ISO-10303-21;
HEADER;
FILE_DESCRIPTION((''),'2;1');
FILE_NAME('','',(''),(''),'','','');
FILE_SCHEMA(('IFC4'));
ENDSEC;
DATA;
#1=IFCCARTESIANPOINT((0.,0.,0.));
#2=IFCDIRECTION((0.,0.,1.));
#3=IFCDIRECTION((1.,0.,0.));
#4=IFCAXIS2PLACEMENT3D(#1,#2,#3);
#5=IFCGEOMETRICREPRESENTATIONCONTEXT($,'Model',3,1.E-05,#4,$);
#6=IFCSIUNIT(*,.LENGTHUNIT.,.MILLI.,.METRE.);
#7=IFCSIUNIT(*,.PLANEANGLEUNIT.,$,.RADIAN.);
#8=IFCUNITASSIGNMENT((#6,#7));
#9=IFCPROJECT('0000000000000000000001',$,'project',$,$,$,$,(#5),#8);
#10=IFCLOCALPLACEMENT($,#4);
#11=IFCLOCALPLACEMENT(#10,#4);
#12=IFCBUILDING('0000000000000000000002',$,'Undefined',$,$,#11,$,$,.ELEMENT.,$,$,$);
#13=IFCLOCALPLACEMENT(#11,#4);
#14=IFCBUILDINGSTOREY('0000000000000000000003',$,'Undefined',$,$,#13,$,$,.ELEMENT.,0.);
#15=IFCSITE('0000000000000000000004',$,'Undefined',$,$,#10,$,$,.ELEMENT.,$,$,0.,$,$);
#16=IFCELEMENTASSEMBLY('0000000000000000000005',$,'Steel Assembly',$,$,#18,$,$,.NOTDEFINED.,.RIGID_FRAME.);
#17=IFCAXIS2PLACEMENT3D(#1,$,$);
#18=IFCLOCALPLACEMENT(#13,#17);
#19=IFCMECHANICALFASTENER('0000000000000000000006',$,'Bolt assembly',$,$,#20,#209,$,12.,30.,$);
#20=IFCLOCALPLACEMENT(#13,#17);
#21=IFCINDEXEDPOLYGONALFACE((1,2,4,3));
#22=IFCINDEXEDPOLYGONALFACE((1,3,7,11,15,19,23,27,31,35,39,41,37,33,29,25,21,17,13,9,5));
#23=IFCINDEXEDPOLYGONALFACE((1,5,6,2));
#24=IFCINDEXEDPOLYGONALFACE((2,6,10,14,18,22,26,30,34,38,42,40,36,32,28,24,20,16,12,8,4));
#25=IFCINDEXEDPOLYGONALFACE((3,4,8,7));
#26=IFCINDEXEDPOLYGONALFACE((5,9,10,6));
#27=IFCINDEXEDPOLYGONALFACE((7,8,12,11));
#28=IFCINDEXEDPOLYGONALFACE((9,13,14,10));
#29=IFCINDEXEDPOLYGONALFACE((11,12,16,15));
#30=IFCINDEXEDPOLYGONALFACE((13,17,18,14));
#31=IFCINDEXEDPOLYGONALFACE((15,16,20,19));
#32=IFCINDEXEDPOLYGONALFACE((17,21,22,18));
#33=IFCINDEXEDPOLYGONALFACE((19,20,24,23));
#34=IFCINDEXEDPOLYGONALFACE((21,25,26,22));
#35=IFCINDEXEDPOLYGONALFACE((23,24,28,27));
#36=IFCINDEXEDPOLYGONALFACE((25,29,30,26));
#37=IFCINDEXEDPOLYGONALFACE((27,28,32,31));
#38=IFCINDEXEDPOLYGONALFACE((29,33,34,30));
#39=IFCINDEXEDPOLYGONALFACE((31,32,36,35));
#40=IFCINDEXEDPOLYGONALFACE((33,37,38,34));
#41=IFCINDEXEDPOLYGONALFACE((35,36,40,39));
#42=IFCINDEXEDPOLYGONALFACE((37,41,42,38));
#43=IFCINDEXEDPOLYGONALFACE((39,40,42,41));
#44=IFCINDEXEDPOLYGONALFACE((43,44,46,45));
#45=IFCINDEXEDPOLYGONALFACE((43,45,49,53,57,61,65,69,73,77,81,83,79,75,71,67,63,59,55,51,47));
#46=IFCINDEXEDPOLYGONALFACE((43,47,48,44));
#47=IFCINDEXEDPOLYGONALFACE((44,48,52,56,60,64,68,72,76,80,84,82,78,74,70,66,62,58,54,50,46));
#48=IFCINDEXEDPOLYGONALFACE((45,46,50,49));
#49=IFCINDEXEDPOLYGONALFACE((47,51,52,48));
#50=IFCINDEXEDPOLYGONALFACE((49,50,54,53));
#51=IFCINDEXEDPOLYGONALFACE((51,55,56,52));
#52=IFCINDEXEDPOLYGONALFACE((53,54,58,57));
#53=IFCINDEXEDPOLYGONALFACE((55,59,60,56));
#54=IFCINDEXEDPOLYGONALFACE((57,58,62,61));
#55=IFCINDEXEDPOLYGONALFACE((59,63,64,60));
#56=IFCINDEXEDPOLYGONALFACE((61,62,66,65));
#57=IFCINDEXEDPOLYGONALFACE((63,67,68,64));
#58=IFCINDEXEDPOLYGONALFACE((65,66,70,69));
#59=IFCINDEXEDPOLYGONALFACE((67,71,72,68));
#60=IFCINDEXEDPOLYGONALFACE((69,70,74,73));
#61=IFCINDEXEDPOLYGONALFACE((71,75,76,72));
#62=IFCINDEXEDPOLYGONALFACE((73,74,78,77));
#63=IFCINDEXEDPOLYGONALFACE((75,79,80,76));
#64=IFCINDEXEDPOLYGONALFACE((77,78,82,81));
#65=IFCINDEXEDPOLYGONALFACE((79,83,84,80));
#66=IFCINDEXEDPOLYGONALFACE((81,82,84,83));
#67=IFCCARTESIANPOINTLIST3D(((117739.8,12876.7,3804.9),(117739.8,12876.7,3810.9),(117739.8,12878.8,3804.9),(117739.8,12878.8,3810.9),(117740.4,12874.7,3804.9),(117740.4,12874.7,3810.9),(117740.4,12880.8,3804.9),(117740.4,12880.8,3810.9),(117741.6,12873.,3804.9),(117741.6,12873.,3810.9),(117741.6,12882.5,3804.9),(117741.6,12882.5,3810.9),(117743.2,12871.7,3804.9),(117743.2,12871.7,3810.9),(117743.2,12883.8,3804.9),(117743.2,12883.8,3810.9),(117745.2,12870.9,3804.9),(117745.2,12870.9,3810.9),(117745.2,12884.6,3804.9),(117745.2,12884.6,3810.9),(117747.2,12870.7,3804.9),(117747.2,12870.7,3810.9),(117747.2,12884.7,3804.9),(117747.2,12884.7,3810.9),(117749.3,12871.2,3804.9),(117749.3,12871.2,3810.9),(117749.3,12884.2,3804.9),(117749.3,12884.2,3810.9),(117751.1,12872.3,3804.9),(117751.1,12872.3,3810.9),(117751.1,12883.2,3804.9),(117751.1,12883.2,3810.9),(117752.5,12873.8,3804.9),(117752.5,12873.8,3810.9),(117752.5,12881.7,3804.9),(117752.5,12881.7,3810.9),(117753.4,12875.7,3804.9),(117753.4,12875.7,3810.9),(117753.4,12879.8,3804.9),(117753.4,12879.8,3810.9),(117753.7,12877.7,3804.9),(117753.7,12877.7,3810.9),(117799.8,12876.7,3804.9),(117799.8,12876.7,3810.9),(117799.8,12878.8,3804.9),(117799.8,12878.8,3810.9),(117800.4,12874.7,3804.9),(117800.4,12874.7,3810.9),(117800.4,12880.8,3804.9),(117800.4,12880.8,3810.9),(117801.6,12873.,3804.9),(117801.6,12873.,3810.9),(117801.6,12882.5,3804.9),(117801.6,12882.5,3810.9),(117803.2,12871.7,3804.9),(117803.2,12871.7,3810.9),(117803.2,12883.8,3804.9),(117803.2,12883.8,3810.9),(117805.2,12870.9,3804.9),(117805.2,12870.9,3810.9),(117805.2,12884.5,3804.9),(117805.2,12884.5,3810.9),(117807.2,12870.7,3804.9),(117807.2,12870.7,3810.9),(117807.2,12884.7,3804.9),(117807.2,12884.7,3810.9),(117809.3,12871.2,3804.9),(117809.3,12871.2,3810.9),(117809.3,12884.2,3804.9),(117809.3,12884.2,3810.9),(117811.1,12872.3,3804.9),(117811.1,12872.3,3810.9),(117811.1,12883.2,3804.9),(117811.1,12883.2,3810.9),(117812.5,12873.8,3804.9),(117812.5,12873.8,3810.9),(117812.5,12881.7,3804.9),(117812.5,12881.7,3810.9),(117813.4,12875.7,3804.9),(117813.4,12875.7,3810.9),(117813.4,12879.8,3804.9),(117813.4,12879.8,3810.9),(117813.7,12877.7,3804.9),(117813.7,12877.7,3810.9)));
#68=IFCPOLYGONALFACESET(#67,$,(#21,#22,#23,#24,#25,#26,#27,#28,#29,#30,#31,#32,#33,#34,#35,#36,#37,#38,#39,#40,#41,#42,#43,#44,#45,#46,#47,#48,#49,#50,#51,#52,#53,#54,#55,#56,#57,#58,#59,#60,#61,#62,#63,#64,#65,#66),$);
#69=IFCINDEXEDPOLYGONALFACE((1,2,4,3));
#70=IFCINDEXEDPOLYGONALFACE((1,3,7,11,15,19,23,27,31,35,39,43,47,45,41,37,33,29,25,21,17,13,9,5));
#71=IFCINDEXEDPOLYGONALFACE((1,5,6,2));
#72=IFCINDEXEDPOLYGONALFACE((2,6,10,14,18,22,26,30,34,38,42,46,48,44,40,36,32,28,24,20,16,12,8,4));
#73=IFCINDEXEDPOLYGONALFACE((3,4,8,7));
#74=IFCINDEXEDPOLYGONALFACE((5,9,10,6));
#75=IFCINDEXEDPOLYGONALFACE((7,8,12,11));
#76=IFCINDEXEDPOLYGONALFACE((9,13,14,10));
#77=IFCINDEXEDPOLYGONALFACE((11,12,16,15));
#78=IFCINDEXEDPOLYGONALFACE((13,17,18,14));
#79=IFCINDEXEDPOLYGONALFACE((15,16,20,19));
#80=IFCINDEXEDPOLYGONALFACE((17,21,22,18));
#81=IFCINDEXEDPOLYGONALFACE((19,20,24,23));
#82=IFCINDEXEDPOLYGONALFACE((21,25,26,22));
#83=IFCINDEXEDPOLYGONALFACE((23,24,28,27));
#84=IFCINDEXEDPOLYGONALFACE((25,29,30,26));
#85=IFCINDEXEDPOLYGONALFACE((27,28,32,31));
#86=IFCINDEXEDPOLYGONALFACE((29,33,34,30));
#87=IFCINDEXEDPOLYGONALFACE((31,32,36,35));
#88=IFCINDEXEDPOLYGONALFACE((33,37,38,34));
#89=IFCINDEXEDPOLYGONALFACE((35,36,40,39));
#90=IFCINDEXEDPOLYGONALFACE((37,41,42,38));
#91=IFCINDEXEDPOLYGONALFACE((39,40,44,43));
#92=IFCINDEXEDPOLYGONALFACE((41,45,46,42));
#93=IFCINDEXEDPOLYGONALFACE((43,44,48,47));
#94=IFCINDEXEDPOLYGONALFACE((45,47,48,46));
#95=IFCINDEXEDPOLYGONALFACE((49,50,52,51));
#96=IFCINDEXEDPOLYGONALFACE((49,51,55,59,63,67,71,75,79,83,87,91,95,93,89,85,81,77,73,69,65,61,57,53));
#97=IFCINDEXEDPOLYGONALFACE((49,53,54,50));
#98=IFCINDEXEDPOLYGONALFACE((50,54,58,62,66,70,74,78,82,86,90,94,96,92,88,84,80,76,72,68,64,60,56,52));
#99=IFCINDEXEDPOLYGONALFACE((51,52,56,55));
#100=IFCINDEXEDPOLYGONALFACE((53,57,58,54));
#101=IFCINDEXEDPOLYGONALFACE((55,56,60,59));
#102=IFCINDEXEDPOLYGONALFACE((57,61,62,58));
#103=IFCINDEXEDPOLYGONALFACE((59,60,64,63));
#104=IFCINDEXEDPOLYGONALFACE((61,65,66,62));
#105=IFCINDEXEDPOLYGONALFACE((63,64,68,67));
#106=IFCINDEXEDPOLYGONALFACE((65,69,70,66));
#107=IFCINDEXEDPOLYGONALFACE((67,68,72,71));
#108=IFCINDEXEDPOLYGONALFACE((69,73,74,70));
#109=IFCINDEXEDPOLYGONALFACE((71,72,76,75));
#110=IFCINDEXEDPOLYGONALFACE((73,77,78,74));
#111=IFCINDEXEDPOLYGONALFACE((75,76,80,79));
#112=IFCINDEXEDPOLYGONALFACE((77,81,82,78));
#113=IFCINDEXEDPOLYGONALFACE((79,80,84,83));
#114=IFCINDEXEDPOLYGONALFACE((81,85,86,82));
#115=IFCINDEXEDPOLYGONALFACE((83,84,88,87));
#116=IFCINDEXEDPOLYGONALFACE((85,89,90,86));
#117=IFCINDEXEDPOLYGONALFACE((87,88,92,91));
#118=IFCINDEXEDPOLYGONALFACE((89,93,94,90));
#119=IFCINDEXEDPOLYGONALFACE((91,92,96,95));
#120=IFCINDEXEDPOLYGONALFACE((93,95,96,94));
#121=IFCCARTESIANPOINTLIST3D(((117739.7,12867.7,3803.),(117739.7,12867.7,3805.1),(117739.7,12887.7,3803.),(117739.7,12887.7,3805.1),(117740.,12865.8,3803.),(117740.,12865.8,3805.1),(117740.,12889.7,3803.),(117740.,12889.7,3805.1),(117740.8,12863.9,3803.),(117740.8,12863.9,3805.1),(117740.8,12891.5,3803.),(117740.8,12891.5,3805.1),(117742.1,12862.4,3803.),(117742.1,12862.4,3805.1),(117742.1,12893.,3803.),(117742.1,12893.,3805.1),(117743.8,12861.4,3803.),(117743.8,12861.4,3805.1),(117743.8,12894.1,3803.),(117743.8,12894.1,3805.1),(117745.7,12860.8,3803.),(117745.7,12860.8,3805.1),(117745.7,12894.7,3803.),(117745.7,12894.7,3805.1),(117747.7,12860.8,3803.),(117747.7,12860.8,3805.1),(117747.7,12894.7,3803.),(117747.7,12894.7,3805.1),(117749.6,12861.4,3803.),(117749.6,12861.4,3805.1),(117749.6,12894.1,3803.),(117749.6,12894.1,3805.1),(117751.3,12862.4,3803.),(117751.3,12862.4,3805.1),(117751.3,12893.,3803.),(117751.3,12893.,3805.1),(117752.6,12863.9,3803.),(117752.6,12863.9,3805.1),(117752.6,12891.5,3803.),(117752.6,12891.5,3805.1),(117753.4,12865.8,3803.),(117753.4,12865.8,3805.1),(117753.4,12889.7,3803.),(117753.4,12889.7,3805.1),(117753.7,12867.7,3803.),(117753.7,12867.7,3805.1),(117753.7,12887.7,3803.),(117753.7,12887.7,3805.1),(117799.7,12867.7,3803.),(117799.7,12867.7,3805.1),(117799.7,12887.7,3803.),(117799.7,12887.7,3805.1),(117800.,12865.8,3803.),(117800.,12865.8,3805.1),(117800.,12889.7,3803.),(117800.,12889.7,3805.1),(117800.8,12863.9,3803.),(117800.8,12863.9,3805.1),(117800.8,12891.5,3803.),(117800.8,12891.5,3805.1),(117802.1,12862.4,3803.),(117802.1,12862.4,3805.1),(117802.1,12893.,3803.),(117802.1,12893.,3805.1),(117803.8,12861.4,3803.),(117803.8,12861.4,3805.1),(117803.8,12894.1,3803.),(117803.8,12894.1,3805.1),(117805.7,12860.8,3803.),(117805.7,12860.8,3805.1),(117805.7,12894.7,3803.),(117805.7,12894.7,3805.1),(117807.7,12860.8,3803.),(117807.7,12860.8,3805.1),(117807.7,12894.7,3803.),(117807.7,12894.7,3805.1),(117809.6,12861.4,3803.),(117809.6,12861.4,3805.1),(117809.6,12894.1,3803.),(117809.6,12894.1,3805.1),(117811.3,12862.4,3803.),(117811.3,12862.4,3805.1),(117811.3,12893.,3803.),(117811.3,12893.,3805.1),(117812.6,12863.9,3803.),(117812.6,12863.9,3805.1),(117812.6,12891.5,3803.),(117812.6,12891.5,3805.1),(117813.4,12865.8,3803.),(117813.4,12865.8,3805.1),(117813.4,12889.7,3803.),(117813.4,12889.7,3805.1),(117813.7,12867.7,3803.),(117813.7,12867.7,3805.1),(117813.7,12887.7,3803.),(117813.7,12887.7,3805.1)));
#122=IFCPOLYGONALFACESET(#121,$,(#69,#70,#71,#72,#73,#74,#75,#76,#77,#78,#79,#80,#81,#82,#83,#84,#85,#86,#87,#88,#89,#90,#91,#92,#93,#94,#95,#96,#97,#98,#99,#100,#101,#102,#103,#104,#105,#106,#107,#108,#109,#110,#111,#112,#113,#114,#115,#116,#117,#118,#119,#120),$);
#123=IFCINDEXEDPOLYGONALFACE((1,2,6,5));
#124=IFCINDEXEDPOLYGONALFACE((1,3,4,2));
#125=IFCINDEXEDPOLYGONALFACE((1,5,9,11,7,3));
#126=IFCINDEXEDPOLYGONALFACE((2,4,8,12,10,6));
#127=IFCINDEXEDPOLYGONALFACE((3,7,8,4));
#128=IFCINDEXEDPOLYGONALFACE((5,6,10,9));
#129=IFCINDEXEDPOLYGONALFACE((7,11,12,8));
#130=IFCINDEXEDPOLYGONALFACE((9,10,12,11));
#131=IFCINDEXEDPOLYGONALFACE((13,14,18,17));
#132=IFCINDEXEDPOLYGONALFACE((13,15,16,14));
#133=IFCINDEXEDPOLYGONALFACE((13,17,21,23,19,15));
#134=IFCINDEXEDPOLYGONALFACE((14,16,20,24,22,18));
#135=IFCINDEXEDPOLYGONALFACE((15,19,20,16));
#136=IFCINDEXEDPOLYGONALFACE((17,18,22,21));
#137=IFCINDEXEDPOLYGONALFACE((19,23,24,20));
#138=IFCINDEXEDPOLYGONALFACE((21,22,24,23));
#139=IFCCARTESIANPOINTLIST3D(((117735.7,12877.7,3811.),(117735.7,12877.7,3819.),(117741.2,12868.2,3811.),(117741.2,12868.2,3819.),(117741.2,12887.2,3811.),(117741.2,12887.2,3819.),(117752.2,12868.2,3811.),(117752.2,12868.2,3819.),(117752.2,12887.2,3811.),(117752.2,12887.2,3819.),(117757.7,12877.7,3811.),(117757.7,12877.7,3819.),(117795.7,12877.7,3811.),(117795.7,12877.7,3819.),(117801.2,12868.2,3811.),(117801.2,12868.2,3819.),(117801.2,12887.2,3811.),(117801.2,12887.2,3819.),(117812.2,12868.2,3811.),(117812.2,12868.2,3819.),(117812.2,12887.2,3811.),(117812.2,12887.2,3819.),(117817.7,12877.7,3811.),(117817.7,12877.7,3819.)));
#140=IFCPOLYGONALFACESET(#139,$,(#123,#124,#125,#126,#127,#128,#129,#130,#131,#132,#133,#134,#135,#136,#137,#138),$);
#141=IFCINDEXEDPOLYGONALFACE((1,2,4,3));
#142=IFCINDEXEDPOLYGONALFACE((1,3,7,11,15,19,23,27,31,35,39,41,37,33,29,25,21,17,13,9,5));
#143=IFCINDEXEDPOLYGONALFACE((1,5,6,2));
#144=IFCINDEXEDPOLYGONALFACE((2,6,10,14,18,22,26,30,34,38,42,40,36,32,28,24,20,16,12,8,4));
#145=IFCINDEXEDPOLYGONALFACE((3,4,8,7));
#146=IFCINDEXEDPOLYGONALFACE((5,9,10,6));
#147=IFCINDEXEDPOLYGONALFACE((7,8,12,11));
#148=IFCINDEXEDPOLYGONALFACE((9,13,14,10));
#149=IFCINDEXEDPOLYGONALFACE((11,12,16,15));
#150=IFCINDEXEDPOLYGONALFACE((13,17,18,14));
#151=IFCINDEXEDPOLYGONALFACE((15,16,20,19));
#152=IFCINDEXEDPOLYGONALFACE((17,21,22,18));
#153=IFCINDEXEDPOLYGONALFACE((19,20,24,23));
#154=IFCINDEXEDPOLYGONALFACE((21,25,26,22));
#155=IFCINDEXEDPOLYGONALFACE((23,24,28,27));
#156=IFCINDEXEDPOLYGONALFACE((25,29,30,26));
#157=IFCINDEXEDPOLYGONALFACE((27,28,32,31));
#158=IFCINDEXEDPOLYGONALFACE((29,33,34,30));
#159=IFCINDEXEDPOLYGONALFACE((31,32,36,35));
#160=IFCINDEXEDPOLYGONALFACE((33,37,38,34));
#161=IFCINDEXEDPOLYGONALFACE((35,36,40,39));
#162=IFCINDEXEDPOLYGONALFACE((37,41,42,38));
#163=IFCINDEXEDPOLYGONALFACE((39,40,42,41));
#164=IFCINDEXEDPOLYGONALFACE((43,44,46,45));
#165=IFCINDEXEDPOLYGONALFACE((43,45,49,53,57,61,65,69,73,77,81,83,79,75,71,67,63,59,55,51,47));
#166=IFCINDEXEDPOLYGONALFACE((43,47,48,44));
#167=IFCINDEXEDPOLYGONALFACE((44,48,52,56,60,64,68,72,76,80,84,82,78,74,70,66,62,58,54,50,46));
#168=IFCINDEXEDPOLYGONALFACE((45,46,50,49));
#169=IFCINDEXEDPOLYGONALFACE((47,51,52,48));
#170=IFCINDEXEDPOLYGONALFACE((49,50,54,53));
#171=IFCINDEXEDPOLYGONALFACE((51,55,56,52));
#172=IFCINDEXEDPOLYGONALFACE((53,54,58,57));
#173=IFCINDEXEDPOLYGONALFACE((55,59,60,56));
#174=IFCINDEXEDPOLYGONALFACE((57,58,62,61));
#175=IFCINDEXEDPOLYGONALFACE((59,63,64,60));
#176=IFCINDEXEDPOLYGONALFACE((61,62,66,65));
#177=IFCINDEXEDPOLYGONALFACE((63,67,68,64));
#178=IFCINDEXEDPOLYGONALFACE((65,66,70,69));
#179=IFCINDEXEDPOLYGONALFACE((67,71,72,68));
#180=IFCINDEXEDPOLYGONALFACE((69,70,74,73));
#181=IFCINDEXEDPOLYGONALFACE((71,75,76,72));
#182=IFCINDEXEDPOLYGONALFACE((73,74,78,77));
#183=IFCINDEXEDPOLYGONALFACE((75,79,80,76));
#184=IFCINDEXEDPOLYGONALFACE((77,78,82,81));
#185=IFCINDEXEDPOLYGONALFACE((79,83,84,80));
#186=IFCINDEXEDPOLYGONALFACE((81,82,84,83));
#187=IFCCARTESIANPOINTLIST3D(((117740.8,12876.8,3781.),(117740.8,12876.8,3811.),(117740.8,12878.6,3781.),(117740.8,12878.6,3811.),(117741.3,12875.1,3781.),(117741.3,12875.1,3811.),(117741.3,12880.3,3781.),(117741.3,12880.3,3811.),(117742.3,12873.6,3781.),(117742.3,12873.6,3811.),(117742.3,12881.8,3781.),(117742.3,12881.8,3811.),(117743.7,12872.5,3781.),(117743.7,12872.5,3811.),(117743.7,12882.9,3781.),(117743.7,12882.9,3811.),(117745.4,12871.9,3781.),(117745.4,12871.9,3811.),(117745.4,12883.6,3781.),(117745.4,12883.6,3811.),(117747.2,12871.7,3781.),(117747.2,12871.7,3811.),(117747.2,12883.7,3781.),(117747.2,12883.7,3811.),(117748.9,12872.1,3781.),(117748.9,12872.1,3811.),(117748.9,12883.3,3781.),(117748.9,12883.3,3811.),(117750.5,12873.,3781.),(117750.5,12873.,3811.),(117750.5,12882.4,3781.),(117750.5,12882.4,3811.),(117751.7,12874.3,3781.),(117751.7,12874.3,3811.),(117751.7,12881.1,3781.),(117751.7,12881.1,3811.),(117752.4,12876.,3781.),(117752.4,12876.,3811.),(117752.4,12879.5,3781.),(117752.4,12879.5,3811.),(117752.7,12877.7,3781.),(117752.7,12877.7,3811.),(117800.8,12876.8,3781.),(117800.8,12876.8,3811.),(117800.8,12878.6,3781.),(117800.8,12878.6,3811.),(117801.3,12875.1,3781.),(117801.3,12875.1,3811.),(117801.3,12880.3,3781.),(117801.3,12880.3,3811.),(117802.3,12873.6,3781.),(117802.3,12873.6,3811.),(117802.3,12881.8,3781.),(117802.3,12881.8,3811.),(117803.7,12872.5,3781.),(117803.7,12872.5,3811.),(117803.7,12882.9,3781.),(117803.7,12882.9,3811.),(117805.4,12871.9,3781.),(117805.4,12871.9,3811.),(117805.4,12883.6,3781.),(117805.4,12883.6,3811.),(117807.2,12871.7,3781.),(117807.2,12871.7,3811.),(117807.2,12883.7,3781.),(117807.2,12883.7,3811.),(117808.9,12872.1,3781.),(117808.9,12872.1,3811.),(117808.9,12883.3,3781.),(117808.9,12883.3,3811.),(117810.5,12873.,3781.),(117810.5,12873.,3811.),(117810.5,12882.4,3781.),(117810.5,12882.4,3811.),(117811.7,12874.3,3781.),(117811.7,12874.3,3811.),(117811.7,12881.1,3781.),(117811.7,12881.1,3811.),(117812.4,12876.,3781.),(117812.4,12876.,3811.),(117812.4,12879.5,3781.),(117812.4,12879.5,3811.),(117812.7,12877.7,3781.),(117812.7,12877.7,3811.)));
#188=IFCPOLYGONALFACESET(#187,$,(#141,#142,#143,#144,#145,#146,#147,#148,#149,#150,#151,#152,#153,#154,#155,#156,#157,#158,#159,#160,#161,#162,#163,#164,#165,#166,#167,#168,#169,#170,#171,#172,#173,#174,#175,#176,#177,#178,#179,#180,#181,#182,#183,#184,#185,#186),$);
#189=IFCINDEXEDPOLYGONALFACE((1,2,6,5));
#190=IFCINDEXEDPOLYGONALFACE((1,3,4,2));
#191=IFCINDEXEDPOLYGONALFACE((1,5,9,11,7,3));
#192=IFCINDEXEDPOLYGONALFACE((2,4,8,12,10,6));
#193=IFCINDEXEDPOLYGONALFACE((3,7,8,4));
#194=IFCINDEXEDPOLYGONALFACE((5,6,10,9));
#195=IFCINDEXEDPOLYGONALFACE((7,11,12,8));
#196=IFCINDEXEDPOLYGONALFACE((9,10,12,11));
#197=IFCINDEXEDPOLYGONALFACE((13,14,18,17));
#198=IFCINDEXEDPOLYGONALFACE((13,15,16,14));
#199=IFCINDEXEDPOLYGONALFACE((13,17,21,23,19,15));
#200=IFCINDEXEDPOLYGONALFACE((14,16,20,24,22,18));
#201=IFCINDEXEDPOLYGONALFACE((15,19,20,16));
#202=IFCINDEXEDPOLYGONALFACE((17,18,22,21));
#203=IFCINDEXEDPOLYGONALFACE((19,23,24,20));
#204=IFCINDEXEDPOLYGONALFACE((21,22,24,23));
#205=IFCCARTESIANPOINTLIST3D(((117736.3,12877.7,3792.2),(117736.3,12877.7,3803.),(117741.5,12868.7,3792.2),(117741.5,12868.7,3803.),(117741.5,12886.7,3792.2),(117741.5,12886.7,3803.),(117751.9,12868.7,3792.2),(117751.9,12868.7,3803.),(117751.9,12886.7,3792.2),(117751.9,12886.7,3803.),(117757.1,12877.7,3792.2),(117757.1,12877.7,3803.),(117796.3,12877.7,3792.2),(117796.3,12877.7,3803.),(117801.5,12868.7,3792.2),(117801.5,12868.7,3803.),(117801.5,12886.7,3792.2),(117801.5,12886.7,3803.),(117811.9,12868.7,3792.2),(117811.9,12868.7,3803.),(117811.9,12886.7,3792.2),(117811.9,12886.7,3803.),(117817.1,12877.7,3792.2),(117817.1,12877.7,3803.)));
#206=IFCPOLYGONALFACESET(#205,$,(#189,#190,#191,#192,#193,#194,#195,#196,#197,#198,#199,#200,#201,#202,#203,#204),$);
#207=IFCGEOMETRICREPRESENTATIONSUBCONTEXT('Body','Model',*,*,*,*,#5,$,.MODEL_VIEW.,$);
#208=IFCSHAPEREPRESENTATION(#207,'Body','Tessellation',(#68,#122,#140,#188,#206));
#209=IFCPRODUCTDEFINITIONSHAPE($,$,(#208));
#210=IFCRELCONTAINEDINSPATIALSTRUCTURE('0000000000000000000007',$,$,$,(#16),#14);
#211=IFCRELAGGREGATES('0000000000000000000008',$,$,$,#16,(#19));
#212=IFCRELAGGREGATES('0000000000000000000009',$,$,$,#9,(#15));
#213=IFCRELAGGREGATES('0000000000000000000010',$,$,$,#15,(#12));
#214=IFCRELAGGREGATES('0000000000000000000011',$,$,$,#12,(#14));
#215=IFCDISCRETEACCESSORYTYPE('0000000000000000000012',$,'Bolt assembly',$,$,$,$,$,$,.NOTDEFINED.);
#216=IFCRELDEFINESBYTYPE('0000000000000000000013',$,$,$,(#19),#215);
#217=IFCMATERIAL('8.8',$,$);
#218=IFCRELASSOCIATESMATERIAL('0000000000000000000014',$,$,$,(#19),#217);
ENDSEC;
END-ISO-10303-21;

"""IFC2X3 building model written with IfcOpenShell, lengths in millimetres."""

from ifc_helpers import new_model, si_unit, frame, frame_2d, origin_with_axes, origin_2d_with_axis, place, context, subcontext, project, spatial, polyline, circle_curve, parameter, trimmed, segment, composite_curve, circle, outline, extrude, source, transform, mapped, material, type_object, element, aggregate, save


model = new_model("IFC2X3")

# Units and contexts
model_context = context("Model", 3, precision=1e-05, world=origin_with_axes())
body_context = subcontext(model_context, "Body", "Model", "MODEL_VIEW")
ifc_project = project(units=[si_unit("LENGTHUNIT", "METRE", prefix="MILLI"), si_unit("PLANEANGLEUNIT", "RADIAN")], contexts=[model_context])

# Site, building, storey
site_placement = place(None, origin_with_axes())
site = spatial("IfcSite", under=ifc_project, at=site_placement, Name="Undefined", CompositionType="ELEMENT", RefElevation=0.0)
building_placement = place(site_placement, origin_with_axes())
building = spatial("IfcBuilding", under=site, at=building_placement, Name="Undefined", CompositionType="ELEMENT")
storey_placement = place(building_placement, origin_with_axes())
storey = spatial("IfcBuildingStorey", under=building, at=storey_placement, Name="Undefined", CompositionType="ELEMENT", Elevation=0.0)

# Element assembly, mechanical fastener
assembly_1_placement = place(storey_placement, origin_with_axes())
assembly_1 = element("IfcElementAssembly", 1, at=assembly_1_placement, inside=storey, Name="Steel Assembly", AssemblyPlace="NOTDEFINED", PredefinedType="RIGID_FRAME")
ifc_material_1 = material(Name="8.8")
discrete_accessory_type_1 = type_object("IfcDiscreteAccessoryType", Name="Bolt assembly")
shared_shape_1 = source(origin_with_axes(), body_context, "Body", "SweptSolid", [
    extrude(circle(Radius=7.0, at=origin_2d_with_axis()), frame((0.0, -2.9, 0.0), z_axis=(0.0, 1.0, 0.0), x_axis=(1.0, 0.0, 0.0)), (0.0, 0.0, 1.0), 6.0),
    extrude(outline(composite_curve([segment(polyline([(7.0, 10.0), (7.0, -10.0)]), True, "CONTINUOUS"), segment(trimmed(circle_curve(frame_2d((0.0, -10.0), x_axis=(1.0, 0.0)), 7.0), [parameter(0.0)], [parameter(3.1416)], False, "PARAMETER"), True, "CONTINUOUS"), segment(polyline([(-7.0, -10.0), (-7.0, 10.0)]), True, "CONTINUOUS"), segment(trimmed(circle_curve(frame_2d((0.0, 10.0), x_axis=(-1.0, 0.0)), 7.0), [parameter(0.0)], [parameter(3.1416)], False, "PARAMETER"), True, "DISCONTINUOUS")], self_intersect=False)), frame((0.0, 2.9, 0.0), z_axis=(0.0, 1.0, 0.0), x_axis=(1.0, 0.0, 0.0)), (0.0, 0.0, 1.0), 2.1),
    extrude(outline(polyline([(11.0, 0.0), (5.5, 9.5), (-5.5, 9.5), (-11.0, 0.0), (-5.5, -9.5), (5.5, -9.5), (11.0, 0.0)])), frame((0.0, -11.0, 0.0), z_axis=(0.0, 1.0, 0.0), x_axis=(1.0, 0.0, 0.0)), (0.0, 0.0, 1.0), 8.0),
    extrude(circle(Radius=6.0, at=origin_2d_with_axis()), frame((0.0, -3.0, 0.0), z_axis=(0.0, 1.0, 0.0), x_axis=(1.0, 0.0, 0.0)), (0.0, 0.0, 1.0), 30.0),
    extrude(outline(polyline([(10.4, 0.0), (5.2, 9.0), (-5.2, 9.0), (-10.4, 0.0), (-5.2, -9.0), (5.2, -9.0), (10.4, 0.0)])), frame((0.0, 5.0, 0.0), z_axis=(0.0, 1.0, 0.0), x_axis=(1.0, 0.0, 0.0)), (0.0, 0.0, 1.0), 10.8),
])
mechanical_fastener_1_placement = place(assembly_1_placement, frame((117701.7, 12832.7, 3808.0), z_axis=(0.000045, 1.0, 0.0), x_axis=(1.0, -0.000045, 0.0)))
mechanical_fastener_1 = element("IfcMechanicalFastener", 2, at=mechanical_fastener_1_placement, type_object=discrete_accessory_type_1, material=ifc_material_1, Name="Bolt assembly", NominalDiameter=12.0, NominalLength=30.0, context=body_context, shape_type="MappedRepresentation", body=[
    mapped(shared_shape_1, transform((45.0, 0.0, 45.0))),
    mapped(shared_shape_1, transform((105.0, 0.0, 45.0))),
])
aggregate(assembly_1, [mechanical_fastener_1])

save(model, "model.ifc")
